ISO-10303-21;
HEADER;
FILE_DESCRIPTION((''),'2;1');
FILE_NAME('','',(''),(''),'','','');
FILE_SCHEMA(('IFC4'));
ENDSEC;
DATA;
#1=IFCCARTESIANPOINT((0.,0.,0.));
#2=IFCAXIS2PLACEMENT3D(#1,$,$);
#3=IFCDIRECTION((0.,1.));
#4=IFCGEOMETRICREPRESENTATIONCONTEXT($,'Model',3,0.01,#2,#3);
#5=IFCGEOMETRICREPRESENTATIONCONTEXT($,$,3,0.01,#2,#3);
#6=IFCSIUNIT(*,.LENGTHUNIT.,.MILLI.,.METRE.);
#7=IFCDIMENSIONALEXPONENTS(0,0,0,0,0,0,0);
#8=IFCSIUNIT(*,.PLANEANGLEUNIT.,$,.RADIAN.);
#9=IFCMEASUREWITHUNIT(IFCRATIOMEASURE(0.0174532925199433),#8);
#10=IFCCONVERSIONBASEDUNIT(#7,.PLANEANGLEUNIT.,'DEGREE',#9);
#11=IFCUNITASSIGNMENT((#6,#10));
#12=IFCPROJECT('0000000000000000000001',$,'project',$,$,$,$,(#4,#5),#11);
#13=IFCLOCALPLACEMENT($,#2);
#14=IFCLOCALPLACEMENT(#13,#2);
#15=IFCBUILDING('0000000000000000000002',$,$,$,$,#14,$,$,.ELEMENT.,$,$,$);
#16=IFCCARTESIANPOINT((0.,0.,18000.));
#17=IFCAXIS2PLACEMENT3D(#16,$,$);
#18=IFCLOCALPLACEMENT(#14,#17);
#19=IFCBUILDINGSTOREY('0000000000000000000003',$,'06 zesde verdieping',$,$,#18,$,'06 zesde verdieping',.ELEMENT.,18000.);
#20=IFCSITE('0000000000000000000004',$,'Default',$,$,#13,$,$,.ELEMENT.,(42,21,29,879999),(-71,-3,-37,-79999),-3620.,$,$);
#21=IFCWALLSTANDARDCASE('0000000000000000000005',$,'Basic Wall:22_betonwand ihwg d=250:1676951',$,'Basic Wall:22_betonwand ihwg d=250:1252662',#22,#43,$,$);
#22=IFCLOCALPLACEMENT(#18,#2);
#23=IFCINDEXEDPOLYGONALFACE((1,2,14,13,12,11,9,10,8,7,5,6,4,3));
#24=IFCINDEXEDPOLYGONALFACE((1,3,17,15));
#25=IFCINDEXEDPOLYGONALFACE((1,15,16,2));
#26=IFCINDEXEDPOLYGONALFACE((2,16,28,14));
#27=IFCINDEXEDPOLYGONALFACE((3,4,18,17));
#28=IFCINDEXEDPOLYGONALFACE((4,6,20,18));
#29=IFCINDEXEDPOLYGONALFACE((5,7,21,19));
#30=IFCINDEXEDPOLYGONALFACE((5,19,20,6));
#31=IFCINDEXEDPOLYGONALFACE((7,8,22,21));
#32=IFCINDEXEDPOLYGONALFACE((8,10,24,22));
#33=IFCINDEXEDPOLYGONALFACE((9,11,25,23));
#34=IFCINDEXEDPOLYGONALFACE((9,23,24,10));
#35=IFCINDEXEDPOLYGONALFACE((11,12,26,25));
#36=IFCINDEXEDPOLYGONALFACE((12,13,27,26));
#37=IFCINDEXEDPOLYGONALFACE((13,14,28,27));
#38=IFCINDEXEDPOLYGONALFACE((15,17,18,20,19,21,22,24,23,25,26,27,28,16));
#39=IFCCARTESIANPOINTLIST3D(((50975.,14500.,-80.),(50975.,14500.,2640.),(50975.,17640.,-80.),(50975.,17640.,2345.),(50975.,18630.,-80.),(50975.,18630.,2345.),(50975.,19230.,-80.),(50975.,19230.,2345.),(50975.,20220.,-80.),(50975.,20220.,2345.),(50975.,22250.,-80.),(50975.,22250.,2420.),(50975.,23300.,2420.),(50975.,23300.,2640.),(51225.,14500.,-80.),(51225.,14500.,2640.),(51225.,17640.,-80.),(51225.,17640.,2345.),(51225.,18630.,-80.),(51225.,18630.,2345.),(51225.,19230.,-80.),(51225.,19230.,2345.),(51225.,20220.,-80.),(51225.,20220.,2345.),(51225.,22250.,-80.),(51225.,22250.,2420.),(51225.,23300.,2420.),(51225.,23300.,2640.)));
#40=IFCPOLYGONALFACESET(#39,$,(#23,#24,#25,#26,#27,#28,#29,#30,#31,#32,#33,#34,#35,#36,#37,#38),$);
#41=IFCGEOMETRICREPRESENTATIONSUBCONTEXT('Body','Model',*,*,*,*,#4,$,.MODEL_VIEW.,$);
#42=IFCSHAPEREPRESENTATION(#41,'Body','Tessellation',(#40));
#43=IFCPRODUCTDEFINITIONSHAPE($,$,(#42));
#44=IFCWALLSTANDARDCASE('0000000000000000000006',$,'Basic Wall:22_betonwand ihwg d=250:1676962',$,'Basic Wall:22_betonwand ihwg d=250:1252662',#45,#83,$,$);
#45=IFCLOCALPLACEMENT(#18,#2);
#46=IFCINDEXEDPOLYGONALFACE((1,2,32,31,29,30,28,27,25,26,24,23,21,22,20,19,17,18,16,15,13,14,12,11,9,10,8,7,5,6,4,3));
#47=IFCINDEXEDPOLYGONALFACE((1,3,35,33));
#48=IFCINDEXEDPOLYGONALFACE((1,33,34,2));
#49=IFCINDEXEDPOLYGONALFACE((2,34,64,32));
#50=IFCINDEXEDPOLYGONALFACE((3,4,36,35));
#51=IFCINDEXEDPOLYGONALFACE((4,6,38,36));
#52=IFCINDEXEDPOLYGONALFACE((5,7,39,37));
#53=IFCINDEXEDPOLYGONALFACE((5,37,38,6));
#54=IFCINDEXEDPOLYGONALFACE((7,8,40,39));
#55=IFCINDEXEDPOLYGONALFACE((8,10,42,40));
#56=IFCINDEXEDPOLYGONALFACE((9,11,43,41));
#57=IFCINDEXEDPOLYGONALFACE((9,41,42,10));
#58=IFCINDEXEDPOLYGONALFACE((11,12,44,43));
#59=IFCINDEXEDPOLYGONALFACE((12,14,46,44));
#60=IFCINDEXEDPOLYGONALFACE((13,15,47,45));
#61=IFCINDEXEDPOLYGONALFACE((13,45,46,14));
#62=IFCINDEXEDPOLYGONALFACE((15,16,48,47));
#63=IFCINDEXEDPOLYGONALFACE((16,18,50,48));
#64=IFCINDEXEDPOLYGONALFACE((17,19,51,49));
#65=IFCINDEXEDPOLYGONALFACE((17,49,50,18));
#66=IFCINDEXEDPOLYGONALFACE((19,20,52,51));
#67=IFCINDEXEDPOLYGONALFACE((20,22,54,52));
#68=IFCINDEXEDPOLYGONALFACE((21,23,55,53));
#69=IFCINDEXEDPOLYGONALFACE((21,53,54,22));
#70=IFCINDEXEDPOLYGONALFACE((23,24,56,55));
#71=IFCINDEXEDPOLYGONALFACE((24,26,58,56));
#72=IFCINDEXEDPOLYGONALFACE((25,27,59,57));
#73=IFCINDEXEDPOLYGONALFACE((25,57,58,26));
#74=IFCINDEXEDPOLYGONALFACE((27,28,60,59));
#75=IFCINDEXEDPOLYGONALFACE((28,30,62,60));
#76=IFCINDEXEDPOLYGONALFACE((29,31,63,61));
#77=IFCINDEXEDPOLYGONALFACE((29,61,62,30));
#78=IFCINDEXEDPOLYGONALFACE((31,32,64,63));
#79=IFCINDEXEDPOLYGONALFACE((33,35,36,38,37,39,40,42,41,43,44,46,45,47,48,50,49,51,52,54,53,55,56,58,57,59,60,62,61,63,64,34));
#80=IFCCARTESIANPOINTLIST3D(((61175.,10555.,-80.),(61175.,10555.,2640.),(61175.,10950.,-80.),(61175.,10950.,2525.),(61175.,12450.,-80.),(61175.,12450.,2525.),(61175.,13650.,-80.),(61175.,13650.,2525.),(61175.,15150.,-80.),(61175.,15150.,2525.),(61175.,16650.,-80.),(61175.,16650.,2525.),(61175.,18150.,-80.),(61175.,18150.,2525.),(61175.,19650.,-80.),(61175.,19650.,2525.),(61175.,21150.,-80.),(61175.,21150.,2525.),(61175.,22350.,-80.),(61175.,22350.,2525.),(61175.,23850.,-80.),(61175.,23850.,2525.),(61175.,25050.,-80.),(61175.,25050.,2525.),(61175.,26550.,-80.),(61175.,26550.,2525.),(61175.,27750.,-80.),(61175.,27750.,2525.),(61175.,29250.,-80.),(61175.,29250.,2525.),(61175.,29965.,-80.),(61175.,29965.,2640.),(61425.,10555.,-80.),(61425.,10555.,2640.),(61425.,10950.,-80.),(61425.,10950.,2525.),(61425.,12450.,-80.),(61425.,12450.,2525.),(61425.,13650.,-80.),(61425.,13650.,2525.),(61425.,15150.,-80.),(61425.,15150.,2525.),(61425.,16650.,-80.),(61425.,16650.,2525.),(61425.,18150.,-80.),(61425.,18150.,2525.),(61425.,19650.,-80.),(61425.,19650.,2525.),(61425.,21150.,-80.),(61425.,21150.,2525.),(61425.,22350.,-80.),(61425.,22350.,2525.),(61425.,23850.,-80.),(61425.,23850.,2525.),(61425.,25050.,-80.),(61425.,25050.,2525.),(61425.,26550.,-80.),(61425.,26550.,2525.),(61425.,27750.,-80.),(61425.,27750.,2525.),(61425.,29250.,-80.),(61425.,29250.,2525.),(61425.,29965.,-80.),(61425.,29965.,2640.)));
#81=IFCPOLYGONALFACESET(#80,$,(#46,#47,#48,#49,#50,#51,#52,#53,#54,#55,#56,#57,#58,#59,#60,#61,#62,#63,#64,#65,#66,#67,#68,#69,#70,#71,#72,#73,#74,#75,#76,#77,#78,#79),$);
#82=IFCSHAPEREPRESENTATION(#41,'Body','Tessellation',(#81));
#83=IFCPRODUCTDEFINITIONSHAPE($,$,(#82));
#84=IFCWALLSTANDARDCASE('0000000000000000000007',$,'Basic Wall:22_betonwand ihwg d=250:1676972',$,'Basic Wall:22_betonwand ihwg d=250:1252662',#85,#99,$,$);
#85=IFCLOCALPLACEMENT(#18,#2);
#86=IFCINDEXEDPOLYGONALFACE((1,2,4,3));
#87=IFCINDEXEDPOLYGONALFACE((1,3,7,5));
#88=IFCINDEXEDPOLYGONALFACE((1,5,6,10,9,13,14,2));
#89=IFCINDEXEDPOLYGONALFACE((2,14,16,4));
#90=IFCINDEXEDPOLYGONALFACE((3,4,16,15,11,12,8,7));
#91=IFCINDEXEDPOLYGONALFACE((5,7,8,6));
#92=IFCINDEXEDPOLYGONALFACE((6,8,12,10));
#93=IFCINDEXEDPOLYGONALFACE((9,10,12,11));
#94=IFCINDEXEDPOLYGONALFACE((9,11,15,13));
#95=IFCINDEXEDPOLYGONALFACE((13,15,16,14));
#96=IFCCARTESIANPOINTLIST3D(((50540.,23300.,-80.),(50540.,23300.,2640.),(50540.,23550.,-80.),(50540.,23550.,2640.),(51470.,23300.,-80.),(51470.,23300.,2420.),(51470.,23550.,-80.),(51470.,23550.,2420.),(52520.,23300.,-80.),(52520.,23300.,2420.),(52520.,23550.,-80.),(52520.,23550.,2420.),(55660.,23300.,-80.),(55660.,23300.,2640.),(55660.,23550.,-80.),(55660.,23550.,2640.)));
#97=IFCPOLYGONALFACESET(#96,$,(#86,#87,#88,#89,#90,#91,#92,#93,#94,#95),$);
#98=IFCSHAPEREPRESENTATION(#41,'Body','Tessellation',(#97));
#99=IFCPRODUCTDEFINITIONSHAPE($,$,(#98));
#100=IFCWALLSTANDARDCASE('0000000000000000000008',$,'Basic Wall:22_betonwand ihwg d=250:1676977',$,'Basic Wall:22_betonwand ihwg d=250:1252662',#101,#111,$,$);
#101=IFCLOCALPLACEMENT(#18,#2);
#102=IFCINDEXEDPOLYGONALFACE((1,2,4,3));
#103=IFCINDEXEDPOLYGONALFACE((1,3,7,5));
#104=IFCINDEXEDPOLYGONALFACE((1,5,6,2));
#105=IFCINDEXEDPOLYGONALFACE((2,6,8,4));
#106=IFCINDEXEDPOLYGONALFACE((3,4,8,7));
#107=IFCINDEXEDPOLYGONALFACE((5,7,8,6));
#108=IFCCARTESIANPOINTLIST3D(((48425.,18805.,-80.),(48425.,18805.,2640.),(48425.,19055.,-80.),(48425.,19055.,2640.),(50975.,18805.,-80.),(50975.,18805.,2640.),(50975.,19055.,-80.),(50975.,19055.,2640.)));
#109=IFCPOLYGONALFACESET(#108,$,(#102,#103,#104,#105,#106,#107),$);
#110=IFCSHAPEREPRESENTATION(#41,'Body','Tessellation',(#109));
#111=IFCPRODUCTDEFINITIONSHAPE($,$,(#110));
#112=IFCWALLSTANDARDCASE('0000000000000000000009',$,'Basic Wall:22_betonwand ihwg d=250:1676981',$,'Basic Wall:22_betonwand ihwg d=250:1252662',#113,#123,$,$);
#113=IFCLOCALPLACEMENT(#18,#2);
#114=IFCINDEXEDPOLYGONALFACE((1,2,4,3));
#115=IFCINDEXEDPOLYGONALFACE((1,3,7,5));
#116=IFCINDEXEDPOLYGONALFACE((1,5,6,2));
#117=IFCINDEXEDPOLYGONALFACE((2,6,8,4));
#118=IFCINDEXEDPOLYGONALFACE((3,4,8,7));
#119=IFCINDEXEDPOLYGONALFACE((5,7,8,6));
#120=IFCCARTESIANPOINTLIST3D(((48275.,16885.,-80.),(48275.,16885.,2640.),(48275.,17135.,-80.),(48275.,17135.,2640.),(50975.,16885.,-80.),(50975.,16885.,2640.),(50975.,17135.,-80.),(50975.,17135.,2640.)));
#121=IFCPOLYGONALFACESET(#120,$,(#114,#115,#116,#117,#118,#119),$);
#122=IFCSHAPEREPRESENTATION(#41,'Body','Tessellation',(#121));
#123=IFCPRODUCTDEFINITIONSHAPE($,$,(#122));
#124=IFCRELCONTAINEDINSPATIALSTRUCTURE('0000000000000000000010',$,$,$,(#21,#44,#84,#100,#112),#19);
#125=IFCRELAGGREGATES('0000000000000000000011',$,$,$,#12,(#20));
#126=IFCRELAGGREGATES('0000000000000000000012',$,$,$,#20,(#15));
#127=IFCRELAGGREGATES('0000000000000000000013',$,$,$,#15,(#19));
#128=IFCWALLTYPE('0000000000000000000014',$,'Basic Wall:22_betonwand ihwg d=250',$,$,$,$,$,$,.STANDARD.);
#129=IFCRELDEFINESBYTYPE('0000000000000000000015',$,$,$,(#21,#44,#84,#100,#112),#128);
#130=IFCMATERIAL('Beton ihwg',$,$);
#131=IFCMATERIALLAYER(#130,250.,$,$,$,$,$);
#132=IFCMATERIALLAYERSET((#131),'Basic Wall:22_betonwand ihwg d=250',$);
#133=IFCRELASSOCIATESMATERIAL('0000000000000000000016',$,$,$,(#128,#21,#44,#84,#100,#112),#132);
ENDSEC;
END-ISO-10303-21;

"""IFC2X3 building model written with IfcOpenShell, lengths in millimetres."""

from ifc_helpers import new_model, entity, si_unit, converted_unit, direction, frame, frame_2d, origin, origin_2d_with_axis, place, context, subcontext, project, spatial, rectangle, extrude, material, layer, layer_set, layer_usage, type_object, element, save


model = new_model("IFC2X3")

# Units and contexts
model_context = context("Model", 3, precision=0.01, world=origin(), true_north=direction((0.0, 1.0)))
context_of_model = context(None, 3, precision=0.01, world=origin(), true_north=direction((0.0, 1.0)))
body_context = subcontext(model_context, "Body", "Model", "MODEL_VIEW")
ifc_project = project(units=[si_unit("LENGTHUNIT", "METRE", prefix="MILLI"), converted_unit("PLANEANGLEUNIT", "DEGREE", entity("IfcRatioMeasure", 0.0174532925199433), si_unit("PLANEANGLEUNIT", "RADIAN"), dimensions=[0, 0, 0, 0, 0, 0, 0])], contexts=[model_context, context_of_model])

# Site, building, storey
site_placement = place(None, origin())
site = spatial("IfcSite", under=ifc_project, at=site_placement, Name="Default", CompositionType="ELEMENT", RefLatitude=(42, 21, 29, 879999), RefLongitude=(-71, -3, -37, -79999), RefElevation=-3620.0)
building_placement = place(site_placement, origin())
building = spatial("IfcBuilding", under=site, at=building_placement, CompositionType="ELEMENT")
storey_placement = place(building_placement, frame((0.0, 0.0, 18000.0)))
storey = spatial("IfcBuildingStorey", under=building, at=storey_placement, Name="06 zesde verdieping", LongName="06 zesde verdieping", CompositionType="ELEMENT", Elevation=18000.0)

# Walls, openings
ifc_material_1 = material(Name="Beton ihwg")
ifc_layer_1 = layer(ifc_material_1, 250.0)
ifc_layer_set_1 = layer_set([ifc_layer_1], Name="Basic Wall:22_betonwand ihwg d=250")
ifc_layer_usage_1 = layer_usage(ifc_layer_set_1, "AXIS2", "NEGATIVE", 125.0)
wall_type_1 = type_object("IfcWallType", Name="Basic Wall:22_betonwand ihwg d=250", PredefinedType="STANDARD", material=ifc_layer_set_1)
wall_1_placement = place(storey_placement, frame((51100.0, 23300.0, -80.0), z_axis=(0.0, 0.0, 1.0), x_axis=(0.0, -1.0, 0.0)))
wall_1 = element("IfcWallStandardCase", 1, at=wall_1_placement, inside=storey, type_object=wall_type_1, material=ifc_layer_usage_1, Name="Basic Wall:22_betonwand ihwg d=250:1676951", ObjectType="Basic Wall:22_betonwand ihwg d=250:1252662", context=body_context, shape_type="SweptSolid", body=[
    extrude(rectangle(XDim=8800.0, YDim=250.0, at=frame_2d((4400.0, 0.0), x_axis=(-1.0, 0.0))), origin(), (0.0, 0.0, 1.0), 2720.0),
])
opening_1_placement = place(wall_1_placement, frame((23300.0, -51100.0, 80.0), z_axis=(0.0, 0.0, 1.0), x_axis=(0.0, 1.0, 0.0)))
element("IfcOpeningElement", 2, at=opening_1_placement, cuts=wall_1, ObjectType="Opening", context=body_context, shape_type="SweptSolid", body=[
    extrude(rectangle(XDim=2425.0, YDim=990.0, at=frame_2d((0.0, 0.0), x_axis=(1.0, 0.0))), frame((50700.0, 19725.0, 1132.5), z_axis=(1.0, 0.0, 0.0), x_axis=(0.0, 0.0, -1.0)), (0.0, 0.0, 1.0), 800.0),
])
opening_2_placement = place(wall_1_placement, frame((23300.0, -51100.0, 80.0), z_axis=(0.0, 0.0, 1.0), x_axis=(0.0, 1.0, 0.0)))
element("IfcOpeningElement", 3, at=opening_2_placement, cuts=wall_1, ObjectType="Opening", context=body_context, shape_type="SweptSolid", body=[
    extrude(rectangle(XDim=2425.0, YDim=990.0, at=origin_2d_with_axis()), frame((50700.0, 18135.0, 1132.5), z_axis=(1.0, 0.0, 0.0), x_axis=(0.0, 0.0, -1.0)), (0.0, 0.0, 1.0), 800.0),
])
opening_3_placement = place(wall_1_placement, frame((23300.0, -51100.0, 80.0), z_axis=(0.0, 0.0, 1.0), x_axis=(0.0, 1.0, 0.0)))
element("IfcOpeningElement", 4, at=opening_3_placement, cuts=wall_1, ObjectType="Opening", context=body_context, shape_type="SweptSolid", body=[
    extrude(rectangle(XDim=2500.0, YDim=1050.0, at=frame_2d((0.0, 0.0), x_axis=(1.0, 0.0))), frame((50700.0, 22775.0, 1170.0), z_axis=(1.0, 0.0, 0.0), x_axis=(0.0, 0.0, -1.0)), (0.0, 0.0, 1.0), 800.0),
])
ifc_layer_usage_2 = layer_usage(ifc_layer_set_1, "AXIS2", "POSITIVE", -125.0)
wall_2_placement = place(storey_placement, frame((61300.0, 29965.0, -80.0), z_axis=(0.0, 0.0, 1.0), x_axis=(0.0, -1.0, 0.0)))
wall_2 = element("IfcWallStandardCase", 5, at=wall_2_placement, inside=storey, type_object=wall_type_1, material=ifc_layer_usage_2, Name="Basic Wall:22_betonwand ihwg d=250:1676962", ObjectType="Basic Wall:22_betonwand ihwg d=250:1252662", context=body_context, shape_type="SweptSolid", body=[
    extrude(rectangle(XDim=19410.0, YDim=250.0, at=frame_2d((9705.0, 0.0), x_axis=(-1.0, 0.0))), origin(), (0.0, 0.0, 1.0), 2720.0),
])
opening_4_placement = place(wall_2_placement, frame((29965.0, -61300.0, 80.0), z_axis=(0.0, 0.0, 1.0), x_axis=(0.0, 1.0, 0.0)))
element("IfcOpeningElement", 6, at=opening_4_placement, cuts=wall_2, ObjectType="Opening", context=body_context, shape_type="SweptSolid", body=[
    extrude(rectangle(XDim=2605.0, YDim=1500.0, at=frame_2d((0.0, 0.0), x_axis=(1.0, 0.0))), frame((59901.0, 28500.0, 1222.5), z_axis=(1.0, 0.0, 0.0), x_axis=(0.0, 0.0, -1.0)), (0.0, 0.0, 1.0), 3048.0),
])
opening_5_placement = place(wall_2_placement, frame((29965.0, -61300.0, 80.0), z_axis=(0.0, 0.0, 1.0), x_axis=(0.0, 1.0, 0.0)))
element("IfcOpeningElement", 7, at=opening_5_placement, cuts=wall_2, ObjectType="Opening", context=body_context, shape_type="SweptSolid", body=[
    extrude(rectangle(XDim=2605.0, YDim=1500.0, at=frame_2d((0.0, 0.0), x_axis=(1.0, 0.0))), frame((59901.0, 25800.0, 1222.5), z_axis=(1.0, 0.0, 0.0), x_axis=(0.0, 0.0, -1.0)), (0.0, 0.0, 1.0), 3048.0),
])
opening_6_placement = place(wall_2_placement, frame((29965.0, -61300.0, 80.0), z_axis=(0.0, 0.0, 1.0), x_axis=(0.0, 1.0, 0.0)))
element("IfcOpeningElement", 8, at=opening_6_placement, cuts=wall_2, ObjectType="Opening", context=body_context, shape_type="SweptSolid", body=[
    extrude(rectangle(XDim=2605.0, YDim=1500.0, at=frame_2d((0.0, 0.0), x_axis=(1.0, 0.0))), frame((59901.0, 23100.0, 1222.5), z_axis=(1.0, 0.0, 0.0), x_axis=(0.0, 0.0, -1.0)), (0.0, 0.0, 1.0), 3048.0),
])
opening_7_placement = place(wall_2_placement, frame((29965.0, -61300.0, 80.0), z_axis=(0.0, 0.0, 1.0), x_axis=(0.0, 1.0, 0.0)))
element("IfcOpeningElement", 9, at=opening_7_placement, cuts=wall_2, ObjectType="Opening", context=body_context, shape_type="SweptSolid", body=[
    extrude(rectangle(XDim=2605.0, YDim=1500.0, at=frame_2d((0.0, 0.0), x_axis=(1.0, 0.0))), frame((59901.0, 17400.0, 1222.5), z_axis=(1.0, 0.0, 0.0), x_axis=(0.0, 0.0, -1.0)), (0.0, 0.0, 1.0), 3048.0),
])
opening_8_placement = place(wall_2_placement, frame((29965.0, -61300.0, 80.0), z_axis=(0.0, 0.0, 1.0), x_axis=(0.0, 1.0, 0.0)))
element("IfcOpeningElement", 10, at=opening_8_placement, cuts=wall_2, ObjectType="Opening", context=body_context, shape_type="SweptSolid", body=[
    extrude(rectangle(XDim=2605.0, YDim=1500.0, at=frame_2d((0.0, 0.0), x_axis=(1.0, 0.0))), frame((59901.0, 14400.0, 1222.5), z_axis=(1.0, 0.0, 0.0), x_axis=(0.0, 0.0, -1.0)), (0.0, 0.0, 1.0), 3048.0),
])
opening_9_placement = place(wall_2_placement, frame((29965.0, -61300.0, 80.0), z_axis=(0.0, 0.0, 1.0), x_axis=(0.0, 1.0, 0.0)))
element("IfcOpeningElement", 11, at=opening_9_placement, cuts=wall_2, ObjectType="Opening", context=body_context, shape_type="SweptSolid", body=[
    extrude(rectangle(XDim=2605.0, YDim=1500.0, at=frame_2d((0.0, 0.0), x_axis=(1.0, 0.0))), frame((59901.0, 20400.0, 1222.5), z_axis=(1.0, 0.0, 0.0), x_axis=(0.0, 0.0, -1.0)), (0.0, 0.0, 1.0), 3048.0),
])
opening_10_placement = place(wall_2_placement, frame((29965.0, -61300.0, 80.0), z_axis=(0.0, 0.0, 1.0), x_axis=(0.0, 1.0, 0.0)))
element("IfcOpeningElement", 12, at=opening_10_placement, cuts=wall_2, ObjectType="Opening", context=body_context, shape_type="SweptSolid", body=[
    extrude(rectangle(XDim=2605.0, YDim=1500.0, at=frame_2d((0.0, 0.0), x_axis=(1.0, 0.0))), frame((59901.0, 11700.0, 1222.5), z_axis=(1.0, 0.0, 0.0), x_axis=(0.0, 0.0, -1.0)), (0.0, 0.0, 1.0), 3048.0),
])
ifc_layer_usage_3 = layer_usage(ifc_layer_set_1, "AXIS2", "POSITIVE", -125.0)
wall_3_placement = place(storey_placement, frame((55660.0, 23425.0, -80.0), z_axis=(0.0, 0.0, 1.0), x_axis=(-1.0, 0.0, 0.0)))
wall_3 = element("IfcWallStandardCase", 13, at=wall_3_placement, inside=storey, type_object=wall_type_1, material=ifc_layer_usage_3, Name="Basic Wall:22_betonwand ihwg d=250:1676972", ObjectType="Basic Wall:22_betonwand ihwg d=250:1252662", context=body_context, shape_type="SweptSolid", body=[
    extrude(rectangle(XDim=5120.0, YDim=250.0, at=frame_2d((2560.0, 0.0), x_axis=(-1.0, 0.0))), origin(), (0.0, 0.0, 1.0), 2720.0),
])
opening_11_placement = place(wall_3_placement, origin())
element("IfcOpeningElement", 14, at=opening_11_placement, cuts=wall_3, ObjectType="Opening", context=body_context, shape_type="SweptSolid", body=[
    extrude(rectangle(XDim=2500.0, YDim=800.0, at=frame_2d((0.0, 0.0), x_axis=(0.0, 1.0))), frame((4560.0, 125.0, 1250.0), z_axis=(0.0, 1.0, 0.0), x_axis=(1.0, 0.0, 0.0)), (0.0, 0.0, 1.0), 1050.0),
])
opening_12_placement = place(wall_3_placement, origin())
element("IfcOpeningElement", 15, at=opening_12_placement, cuts=wall_3, ObjectType="Opening", context=body_context, shape_type="SweptSolid", body=[
    extrude(rectangle(XDim=2500.0, YDim=800.0, at=frame_2d((0.0, 0.0), x_axis=(0.0, 1.0))), frame((2735.0, 125.0, 1250.0), z_axis=(0.0, 1.0, 0.0), x_axis=(1.0, 0.0, 0.0)), (0.0, 0.0, 1.0), 1034.0),
])
opening_13_placement = place(wall_3_placement, frame((55660.0, 23425.0, 80.0), z_axis=(0.0, 0.0, 1.0), x_axis=(-1.0, 0.0, 0.0)))
element("IfcOpeningElement", 16, at=opening_13_placement, cuts=wall_3, ObjectType="Opening", context=body_context, shape_type="SweptSolid", body=[
    extrude(rectangle(XDim=2500.0, YDim=1050.0, at=frame_2d((0.0, 0.0), x_axis=(0.0, 1.0))), frame((51995.0, 23825.0, 1170.0), z_axis=(0.0, -1.0, 0.0), x_axis=(-1.0, 0.0, 0.0)), (0.0, 0.0, 1.0), 800.0),
])

# Walls
ifc_layer_usage_4 = layer_usage(ifc_layer_set_1, "AXIS2", "POSITIVE", -125.0)
wall_4_placement = place(storey_placement, frame((50975.0, 18930.0, -80.0), z_axis=(0.0, 0.0, 1.0), x_axis=(-1.0, 0.0, 0.0)))
element("IfcWallStandardCase", 17, at=wall_4_placement, inside=storey, type_object=wall_type_1, material=ifc_layer_usage_4, Name="Basic Wall:22_betonwand ihwg d=250:1676977", ObjectType="Basic Wall:22_betonwand ihwg d=250:1252662", context=body_context, shape_type="SweptSolid", body=[
    extrude(rectangle(XDim=2550.0, YDim=250.0, at=frame_2d((1275.0, 0.0), x_axis=(-1.0, 0.0))), origin(), (0.0, 0.0, 1.0), 2720.0),
])
ifc_layer_usage_5 = layer_usage(ifc_layer_set_1, "AXIS2", "POSITIVE", -125.0)
wall_5_placement = place(storey_placement, frame((50975.0, 17010.0, -80.0), z_axis=(0.0, 0.0, 1.0), x_axis=(-1.0, 0.0, 0.0)))
element("IfcWallStandardCase", 18, at=wall_5_placement, inside=storey, type_object=wall_type_1, material=ifc_layer_usage_5, Name="Basic Wall:22_betonwand ihwg d=250:1676981", ObjectType="Basic Wall:22_betonwand ihwg d=250:1252662", context=body_context, shape_type="SweptSolid", body=[
    extrude(rectangle(XDim=2700.0, YDim=250.0, at=frame_2d((1350.0, 0.0), x_axis=(-1.0, 0.0))), origin(), (0.0, 0.0, 1.0), 2720.0),
])

save(model, "model.ifc")
